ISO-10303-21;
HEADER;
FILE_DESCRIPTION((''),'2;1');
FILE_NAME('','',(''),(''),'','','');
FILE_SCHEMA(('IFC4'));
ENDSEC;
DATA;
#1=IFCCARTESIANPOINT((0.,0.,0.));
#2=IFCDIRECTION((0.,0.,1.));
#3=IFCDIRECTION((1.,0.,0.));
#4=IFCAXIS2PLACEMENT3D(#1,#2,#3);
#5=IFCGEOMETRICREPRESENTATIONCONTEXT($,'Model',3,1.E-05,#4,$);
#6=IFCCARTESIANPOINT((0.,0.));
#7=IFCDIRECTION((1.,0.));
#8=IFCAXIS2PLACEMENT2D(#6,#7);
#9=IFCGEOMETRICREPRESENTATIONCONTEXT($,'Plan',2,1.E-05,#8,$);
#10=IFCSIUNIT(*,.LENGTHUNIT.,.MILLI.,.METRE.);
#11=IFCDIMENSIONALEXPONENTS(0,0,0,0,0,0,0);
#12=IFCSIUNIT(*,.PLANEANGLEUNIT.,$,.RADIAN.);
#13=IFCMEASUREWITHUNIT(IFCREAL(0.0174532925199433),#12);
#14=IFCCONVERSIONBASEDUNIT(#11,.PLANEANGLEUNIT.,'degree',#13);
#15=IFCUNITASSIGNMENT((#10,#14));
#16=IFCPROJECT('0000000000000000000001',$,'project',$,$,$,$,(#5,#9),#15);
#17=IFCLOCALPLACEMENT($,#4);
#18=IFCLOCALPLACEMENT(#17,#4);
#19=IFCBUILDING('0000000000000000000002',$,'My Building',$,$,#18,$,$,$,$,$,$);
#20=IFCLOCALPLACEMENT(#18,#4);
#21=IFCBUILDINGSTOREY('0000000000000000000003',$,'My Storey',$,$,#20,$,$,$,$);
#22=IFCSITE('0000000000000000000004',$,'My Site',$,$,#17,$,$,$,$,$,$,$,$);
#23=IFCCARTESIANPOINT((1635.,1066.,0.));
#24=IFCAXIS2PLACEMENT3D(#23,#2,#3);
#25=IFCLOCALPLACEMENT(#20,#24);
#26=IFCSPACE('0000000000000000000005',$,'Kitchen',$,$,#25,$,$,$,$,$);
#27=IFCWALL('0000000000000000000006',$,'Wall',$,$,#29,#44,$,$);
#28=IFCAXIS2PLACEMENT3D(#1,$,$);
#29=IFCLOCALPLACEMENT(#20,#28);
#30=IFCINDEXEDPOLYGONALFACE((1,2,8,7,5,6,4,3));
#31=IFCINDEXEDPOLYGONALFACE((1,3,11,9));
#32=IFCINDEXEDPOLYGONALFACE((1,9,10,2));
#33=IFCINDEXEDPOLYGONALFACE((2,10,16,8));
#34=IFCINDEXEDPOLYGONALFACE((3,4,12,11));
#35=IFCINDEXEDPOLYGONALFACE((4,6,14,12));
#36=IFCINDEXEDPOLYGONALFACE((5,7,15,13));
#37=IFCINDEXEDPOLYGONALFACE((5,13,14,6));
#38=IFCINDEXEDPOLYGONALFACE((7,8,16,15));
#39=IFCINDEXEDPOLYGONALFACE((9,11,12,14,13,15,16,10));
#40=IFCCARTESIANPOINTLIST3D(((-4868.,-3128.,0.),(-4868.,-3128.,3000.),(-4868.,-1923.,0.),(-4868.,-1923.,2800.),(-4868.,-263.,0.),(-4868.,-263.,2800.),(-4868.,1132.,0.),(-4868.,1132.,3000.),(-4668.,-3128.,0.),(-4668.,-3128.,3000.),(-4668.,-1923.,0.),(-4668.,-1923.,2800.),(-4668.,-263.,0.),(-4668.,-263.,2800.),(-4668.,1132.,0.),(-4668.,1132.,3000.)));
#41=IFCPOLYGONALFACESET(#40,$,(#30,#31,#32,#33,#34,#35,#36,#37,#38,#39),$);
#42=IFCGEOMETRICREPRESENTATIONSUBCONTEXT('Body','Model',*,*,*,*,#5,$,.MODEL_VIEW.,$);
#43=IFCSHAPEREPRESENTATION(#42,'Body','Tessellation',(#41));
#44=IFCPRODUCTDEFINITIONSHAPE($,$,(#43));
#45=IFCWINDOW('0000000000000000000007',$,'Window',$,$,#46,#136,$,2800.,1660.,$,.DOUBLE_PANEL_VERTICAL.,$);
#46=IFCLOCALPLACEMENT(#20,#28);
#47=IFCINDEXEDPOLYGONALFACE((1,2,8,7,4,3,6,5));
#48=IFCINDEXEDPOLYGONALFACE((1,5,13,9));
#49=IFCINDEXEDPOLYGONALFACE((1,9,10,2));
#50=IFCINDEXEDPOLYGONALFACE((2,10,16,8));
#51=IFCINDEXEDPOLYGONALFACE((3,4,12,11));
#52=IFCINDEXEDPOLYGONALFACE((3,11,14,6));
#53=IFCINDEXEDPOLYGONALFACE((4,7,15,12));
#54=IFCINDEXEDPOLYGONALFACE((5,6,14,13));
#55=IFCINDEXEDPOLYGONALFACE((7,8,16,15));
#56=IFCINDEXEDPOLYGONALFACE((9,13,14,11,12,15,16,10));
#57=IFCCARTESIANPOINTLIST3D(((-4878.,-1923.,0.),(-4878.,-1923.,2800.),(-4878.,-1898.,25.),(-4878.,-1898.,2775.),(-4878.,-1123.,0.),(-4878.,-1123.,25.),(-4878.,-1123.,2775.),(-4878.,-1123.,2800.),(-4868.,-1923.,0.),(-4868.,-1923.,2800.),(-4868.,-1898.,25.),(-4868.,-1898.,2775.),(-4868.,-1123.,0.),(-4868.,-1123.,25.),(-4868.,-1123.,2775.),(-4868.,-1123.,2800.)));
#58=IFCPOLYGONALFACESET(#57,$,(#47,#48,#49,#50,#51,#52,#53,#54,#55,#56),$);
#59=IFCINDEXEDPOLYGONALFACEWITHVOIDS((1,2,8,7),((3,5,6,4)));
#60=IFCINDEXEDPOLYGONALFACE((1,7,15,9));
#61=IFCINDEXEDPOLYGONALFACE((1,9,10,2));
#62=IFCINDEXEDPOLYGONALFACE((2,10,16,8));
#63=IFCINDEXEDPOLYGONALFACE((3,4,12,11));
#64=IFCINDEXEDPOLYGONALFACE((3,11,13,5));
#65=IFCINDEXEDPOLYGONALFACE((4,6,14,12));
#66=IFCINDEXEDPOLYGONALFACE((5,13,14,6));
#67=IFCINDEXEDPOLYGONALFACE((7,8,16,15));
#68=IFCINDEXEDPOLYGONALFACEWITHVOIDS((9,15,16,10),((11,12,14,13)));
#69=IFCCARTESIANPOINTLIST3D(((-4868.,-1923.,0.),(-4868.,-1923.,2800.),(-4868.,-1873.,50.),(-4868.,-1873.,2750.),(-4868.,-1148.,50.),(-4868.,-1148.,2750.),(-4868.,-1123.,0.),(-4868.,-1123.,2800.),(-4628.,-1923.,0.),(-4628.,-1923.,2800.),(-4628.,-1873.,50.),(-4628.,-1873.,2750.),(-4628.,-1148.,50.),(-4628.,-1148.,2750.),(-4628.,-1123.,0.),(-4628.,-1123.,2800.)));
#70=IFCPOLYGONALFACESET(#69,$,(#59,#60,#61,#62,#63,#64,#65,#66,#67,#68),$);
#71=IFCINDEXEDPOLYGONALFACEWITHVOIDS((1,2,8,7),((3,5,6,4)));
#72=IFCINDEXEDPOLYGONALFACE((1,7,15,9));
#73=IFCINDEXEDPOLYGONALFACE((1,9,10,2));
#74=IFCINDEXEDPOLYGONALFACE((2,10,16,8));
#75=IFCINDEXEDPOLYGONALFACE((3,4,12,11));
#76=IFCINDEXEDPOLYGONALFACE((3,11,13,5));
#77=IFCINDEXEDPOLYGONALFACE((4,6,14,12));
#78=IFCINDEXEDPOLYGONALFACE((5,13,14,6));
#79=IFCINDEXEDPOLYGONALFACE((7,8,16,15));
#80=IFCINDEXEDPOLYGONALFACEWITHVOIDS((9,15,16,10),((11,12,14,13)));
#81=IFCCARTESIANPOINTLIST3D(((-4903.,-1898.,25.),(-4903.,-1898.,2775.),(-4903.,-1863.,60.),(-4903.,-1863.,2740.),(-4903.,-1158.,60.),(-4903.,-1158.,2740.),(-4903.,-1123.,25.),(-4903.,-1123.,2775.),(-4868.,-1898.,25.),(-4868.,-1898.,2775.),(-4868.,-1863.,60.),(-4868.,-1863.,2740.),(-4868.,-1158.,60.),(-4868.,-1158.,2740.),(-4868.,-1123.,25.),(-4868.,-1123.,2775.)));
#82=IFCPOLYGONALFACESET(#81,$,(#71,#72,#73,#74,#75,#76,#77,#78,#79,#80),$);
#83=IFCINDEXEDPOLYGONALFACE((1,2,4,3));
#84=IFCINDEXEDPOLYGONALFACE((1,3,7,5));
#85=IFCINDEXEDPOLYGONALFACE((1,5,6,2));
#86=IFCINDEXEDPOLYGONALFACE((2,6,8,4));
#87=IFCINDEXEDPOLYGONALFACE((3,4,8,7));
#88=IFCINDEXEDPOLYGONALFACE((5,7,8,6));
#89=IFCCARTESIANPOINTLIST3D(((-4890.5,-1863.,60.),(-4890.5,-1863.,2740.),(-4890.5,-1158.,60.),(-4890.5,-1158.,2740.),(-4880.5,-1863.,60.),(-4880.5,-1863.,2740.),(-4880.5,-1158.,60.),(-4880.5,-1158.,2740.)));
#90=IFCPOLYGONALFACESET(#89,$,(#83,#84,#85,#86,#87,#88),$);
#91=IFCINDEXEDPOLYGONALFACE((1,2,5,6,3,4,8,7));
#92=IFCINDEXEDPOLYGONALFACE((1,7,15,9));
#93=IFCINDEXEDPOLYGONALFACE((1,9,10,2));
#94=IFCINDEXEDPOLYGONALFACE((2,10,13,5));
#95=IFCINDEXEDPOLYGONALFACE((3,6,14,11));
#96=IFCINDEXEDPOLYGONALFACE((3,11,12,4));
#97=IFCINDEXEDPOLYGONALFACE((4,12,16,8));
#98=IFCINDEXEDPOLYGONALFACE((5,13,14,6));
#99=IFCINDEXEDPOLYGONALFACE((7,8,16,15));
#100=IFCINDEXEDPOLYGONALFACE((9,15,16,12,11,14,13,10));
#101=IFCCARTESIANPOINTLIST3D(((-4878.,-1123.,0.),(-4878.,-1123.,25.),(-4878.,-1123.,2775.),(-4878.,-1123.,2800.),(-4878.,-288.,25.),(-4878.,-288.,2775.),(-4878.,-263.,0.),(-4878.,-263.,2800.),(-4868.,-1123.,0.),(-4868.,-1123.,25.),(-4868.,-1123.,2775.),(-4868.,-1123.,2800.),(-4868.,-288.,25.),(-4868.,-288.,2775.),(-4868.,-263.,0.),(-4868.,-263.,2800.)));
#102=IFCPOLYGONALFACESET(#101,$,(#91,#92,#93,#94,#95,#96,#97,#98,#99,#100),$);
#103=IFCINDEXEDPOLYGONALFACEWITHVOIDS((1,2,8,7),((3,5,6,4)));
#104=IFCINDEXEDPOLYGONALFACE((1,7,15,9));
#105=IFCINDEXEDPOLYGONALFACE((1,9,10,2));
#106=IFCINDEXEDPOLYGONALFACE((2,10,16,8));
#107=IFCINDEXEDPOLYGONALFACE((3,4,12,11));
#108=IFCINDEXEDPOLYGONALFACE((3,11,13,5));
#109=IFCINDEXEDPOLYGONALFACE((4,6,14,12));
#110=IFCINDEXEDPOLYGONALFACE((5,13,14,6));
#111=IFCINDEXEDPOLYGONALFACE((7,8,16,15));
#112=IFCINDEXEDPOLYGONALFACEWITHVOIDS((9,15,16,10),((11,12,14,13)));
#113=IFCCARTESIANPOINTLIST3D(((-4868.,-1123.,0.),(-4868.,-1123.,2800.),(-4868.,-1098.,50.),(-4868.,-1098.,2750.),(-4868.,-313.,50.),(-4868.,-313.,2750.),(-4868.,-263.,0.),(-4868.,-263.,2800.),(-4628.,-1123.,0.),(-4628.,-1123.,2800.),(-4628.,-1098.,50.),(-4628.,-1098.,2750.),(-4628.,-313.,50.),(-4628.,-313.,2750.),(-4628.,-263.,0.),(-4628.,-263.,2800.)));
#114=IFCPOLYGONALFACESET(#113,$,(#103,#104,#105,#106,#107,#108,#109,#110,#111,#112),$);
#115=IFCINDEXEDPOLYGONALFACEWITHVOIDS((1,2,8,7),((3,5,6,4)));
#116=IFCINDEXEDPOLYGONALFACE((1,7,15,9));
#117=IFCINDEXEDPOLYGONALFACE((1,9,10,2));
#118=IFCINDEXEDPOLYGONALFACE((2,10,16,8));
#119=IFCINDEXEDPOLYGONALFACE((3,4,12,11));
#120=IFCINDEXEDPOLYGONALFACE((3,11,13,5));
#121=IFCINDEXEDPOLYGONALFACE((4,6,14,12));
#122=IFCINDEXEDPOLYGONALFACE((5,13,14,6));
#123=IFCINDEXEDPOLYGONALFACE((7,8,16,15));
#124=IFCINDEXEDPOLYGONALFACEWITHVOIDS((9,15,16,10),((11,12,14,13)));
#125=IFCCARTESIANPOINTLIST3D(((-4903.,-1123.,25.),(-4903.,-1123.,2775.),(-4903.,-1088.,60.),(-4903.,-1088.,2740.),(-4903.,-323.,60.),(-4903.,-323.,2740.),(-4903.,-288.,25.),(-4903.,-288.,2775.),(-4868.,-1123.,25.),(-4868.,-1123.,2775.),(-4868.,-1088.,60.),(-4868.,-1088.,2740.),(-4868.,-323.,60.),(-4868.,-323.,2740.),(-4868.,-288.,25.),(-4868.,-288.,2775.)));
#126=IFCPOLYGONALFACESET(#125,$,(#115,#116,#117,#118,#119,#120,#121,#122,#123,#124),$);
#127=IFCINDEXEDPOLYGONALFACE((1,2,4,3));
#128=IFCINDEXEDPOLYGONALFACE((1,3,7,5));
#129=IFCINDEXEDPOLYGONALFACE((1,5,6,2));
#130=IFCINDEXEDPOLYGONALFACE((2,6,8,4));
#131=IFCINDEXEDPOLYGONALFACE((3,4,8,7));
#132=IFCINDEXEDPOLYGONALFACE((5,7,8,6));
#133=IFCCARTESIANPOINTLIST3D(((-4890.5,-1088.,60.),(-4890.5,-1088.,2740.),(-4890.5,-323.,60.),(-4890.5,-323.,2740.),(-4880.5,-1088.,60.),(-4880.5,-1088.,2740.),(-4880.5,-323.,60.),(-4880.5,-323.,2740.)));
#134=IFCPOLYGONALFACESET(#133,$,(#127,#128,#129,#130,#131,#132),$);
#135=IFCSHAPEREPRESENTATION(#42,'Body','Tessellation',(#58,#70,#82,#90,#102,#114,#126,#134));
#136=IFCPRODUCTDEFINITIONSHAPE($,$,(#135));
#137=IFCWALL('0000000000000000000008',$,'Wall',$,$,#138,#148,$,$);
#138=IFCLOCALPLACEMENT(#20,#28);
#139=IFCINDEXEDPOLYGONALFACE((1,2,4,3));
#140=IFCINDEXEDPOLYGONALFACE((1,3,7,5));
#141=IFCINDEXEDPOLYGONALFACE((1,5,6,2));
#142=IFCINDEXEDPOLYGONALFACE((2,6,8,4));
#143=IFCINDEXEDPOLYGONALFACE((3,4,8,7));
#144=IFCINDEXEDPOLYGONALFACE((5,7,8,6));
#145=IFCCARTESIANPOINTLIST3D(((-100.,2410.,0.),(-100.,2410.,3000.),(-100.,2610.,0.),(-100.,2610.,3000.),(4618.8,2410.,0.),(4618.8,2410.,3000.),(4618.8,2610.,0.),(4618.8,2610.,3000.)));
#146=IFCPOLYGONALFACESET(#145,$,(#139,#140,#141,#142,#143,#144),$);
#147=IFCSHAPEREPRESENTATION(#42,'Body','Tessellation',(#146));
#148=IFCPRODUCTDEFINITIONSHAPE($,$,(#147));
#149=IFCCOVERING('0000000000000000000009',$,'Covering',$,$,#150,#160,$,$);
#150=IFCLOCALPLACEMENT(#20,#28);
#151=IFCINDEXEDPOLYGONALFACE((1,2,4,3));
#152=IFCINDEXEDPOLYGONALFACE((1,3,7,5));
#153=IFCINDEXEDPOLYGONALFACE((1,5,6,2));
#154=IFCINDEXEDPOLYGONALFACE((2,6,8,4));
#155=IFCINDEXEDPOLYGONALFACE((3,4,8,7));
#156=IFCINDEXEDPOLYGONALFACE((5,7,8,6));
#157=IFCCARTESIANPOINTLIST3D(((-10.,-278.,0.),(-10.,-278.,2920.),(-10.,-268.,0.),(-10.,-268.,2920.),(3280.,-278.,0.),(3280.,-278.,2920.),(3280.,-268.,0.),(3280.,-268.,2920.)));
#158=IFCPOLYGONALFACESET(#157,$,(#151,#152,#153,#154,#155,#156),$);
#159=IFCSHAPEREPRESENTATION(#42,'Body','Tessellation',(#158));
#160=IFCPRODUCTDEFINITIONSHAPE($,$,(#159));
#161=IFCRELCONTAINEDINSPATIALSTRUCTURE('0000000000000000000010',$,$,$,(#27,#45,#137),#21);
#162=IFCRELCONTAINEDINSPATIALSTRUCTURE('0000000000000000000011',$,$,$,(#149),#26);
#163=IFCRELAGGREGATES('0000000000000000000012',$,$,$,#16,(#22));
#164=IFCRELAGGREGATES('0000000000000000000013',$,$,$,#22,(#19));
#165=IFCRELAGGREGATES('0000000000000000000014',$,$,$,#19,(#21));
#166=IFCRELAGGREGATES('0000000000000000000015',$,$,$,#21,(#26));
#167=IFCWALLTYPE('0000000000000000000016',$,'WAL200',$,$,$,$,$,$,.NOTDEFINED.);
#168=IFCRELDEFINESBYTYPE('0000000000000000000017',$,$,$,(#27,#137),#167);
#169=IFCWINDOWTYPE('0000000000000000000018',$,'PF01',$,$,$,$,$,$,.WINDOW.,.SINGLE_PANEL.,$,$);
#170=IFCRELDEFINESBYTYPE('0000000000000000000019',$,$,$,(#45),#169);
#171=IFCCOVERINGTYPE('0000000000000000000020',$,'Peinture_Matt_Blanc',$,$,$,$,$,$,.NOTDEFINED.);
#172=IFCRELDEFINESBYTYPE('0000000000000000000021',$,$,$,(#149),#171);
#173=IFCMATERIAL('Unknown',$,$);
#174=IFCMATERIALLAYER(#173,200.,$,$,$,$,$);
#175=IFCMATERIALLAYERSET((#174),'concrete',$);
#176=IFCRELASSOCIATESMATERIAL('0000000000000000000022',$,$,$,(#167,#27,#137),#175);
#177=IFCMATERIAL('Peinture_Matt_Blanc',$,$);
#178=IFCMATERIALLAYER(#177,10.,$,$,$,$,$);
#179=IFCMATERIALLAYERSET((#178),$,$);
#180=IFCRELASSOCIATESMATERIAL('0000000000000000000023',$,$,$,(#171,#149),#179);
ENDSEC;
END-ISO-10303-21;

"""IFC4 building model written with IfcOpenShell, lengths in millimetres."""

from ifc_helpers import new_model, entity, si_unit, converted_unit, frame, origin_with_axes, origin_2d_with_axis, place, context, subcontext, project, spatial, line, indexed_curve, outline, extrude, clip, halfspace, shape, source, transform, mapped, material, layer, layer_set, layer_usage, type_object, type_shapes, element, fill, save


model = new_model("IFC4")

# Units and contexts
model_context = context("Model", 3, precision=1e-05, world=origin_with_axes())
plan_context = context("Plan", 2, precision=1e-05, world=origin_2d_with_axis())
body_context_1 = subcontext(model_context, "Body", "Model", "MODEL_VIEW")
body_context_2 = subcontext(plan_context, "Body", "Plan", "PLAN_VIEW")
ifc_project = project(units=[si_unit("LENGTHUNIT", "METRE", prefix="MILLI"), converted_unit("PLANEANGLEUNIT", "degree", entity("IfcReal", 0.0174532925199433), si_unit("PLANEANGLEUNIT", "RADIAN"), dimensions=[0, 0, 0, 0, 0, 0, 0])], contexts=[model_context, plan_context])

# Site, building, storey
site_placement = place(None, origin_with_axes())
site = spatial("IfcSite", under=ifc_project, at=site_placement, Name="My Site")
building_placement = place(site_placement, origin_with_axes())
building = spatial("IfcBuilding", under=site, at=building_placement, Name="My Building")
storey_placement = place(building_placement, origin_with_axes())
storey = spatial("IfcBuildingStorey", under=building, at=storey_placement, Name="My Storey")

# Shared definitions
ifc_material_1 = material(Name="Unknown")

# Shared definitions
space_1_placement = place(storey_placement, frame((1635.0, 1066.0, 0.0), z_axis=(0.0, 0.0, 1.0), x_axis=(1.0, 0.0, 0.0)))
space_1 = spatial("IfcSpace", under=storey, at=space_1_placement, Name="Kitchen")

# Shared definitions
ifc_layer_1 = layer(ifc_material_1, 200.0)
ifc_layer_set_1 = layer_set([ifc_layer_1], Name="concrete")
wall_type_1 = type_object("IfcWallType", Name="WAL200", PredefinedType="NOTDEFINED", material=ifc_layer_set_1)

# Wall, opening, window
ifc_layer_usage_1 = layer_usage(ifc_layer_set_1, "AXIS2", "POSITIVE", 0.0)
wall_1_placement = place(storey_placement, frame((-4868.0, 1132.0, 0.0), z_axis=(0.0, 0.0, 1.0), x_axis=(-0.000001, -1.0, 0.0)))
wall_1 = element("IfcWall", 1, at=wall_1_placement, inside=storey, type_object=wall_type_1, material=ifc_layer_usage_1, Name="Wall", context=body_context_1, shape_type="SweptSolid", body=[
    extrude(outline(indexed_curve([(0.0, 0.0), (0.0, 200.0), (4260.0, 200.0), (4260.0, 0.0), (0.0, 0.0)], self_intersect=False)), origin_with_axes(), (0.0, 0.0, 1.0), 3000.0),
])
shared_shape_1 = source(origin_with_axes(), body_context_1, "Body", "SweptSolid", [
    extrude(outline(indexed_curve([(0.0, 0.0), (1660.0, 0.0), (1660.0, 2800.0), (0.0, 2800.0)], segments=[line(1, 2, 3, 4, 1)])), frame((0.0, -100.0, 0.0), z_axis=(0.0, -1.0, 0.0), x_axis=(1.0, 0.0, 0.0)), (0.0, 0.0, -1.0), 400.0),
])
opening_1_placement = place(wall_1_placement, frame((3055.0, 290.0, 0.0), z_axis=(0.0, 0.0, 1.0), x_axis=(-1.0, 0.0, 0.0)))
opening_1 = element("IfcOpeningElement", 2, at=opening_1_placement, cuts=wall_1, PredefinedType="OPENING", context=body_context_1, shape_type="MappedRepresentation", body=[
    mapped(shared_shape_1, transform((0.0, 0.0, 0.0), x_axis=(1.0, 0.0, 0.0), y_axis=(0.0, 1.0, 0.0), z_axis=(0.0, 0.0, 1.0), scale=1.0)),
])
window_type = type_object("IfcWindowType", Name="PF01", PartitioningType="SINGLE_PANEL", PredefinedType="WINDOW")
shared_shape_2 = source(origin_with_axes(), body_context_1, "Body", "SweptSolid", [
    extrude(outline(indexed_curve([(800.0, 0.0), (0.0, 0.0), (0.0, 2800.0), (800.0, 2800.0), (800.0, 2775.0), (25.0, 2775.0), (25.0, 25.0), (800.0, 25.0)], segments=[line(1, 2, 3, 4, 5, 6, 7, 8, 1)])), frame((0.0, 290.0, 0.0), z_axis=(0.0, -1.0, 0.0), x_axis=(1.0, 0.0, 0.0)), (0.0, 0.0, -1.0), 10.0),
    extrude(outline(indexed_curve([(0.0, 0.0), (800.0, 0.0), (800.0, 2800.0), (0.0, 2800.0)], segments=[line(1, 2, 3, 4, 1)]), holes=[indexed_curve([(50.0, 50.0), (775.0, 50.0), (775.0, 2750.0), (50.0, 2750.0)], segments=[line(1, 2, 3, 4, 1)])]), frame((0.0, 50.0, 0.0), z_axis=(0.0, -1.0, 0.0), x_axis=(1.0, 0.0, 0.0)), (0.0, 0.0, -1.0), 240.0),
    extrude(outline(indexed_curve([(0.0, 0.0), (775.0, 0.0), (775.0, 2750.0), (0.0, 2750.0)], segments=[line(1, 2, 3, 4, 1)]), holes=[indexed_curve([(35.0, 35.0), (740.0, 35.0), (740.0, 2715.0), (35.0, 2715.0)], segments=[line(1, 2, 3, 4, 1)])]), frame((25.0, 290.0, 25.0), z_axis=(0.0, -1.0, 0.0), x_axis=(1.0, 0.0, 0.0)), (0.0, 0.0, -1.0), 35.0),
    extrude(outline(indexed_curve([(35.0, 35.0), (740.0, 35.0), (740.0, 2715.0), (35.0, 2715.0)], segments=[line(1, 2, 3, 4, 1)])), frame((25.0, 302.5, 25.0), z_axis=(0.0, -1.0, 0.0), x_axis=(1.0, 0.0, 0.0)), (0.0, 0.0, -1.0), 10.0),
    extrude(outline(indexed_curve([(0.0, 2800.0), (860.0, 2800.0), (860.0, 0.0), (0.0, 0.0), (0.0, 25.0), (835.0, 25.0), (835.0, 2775.0), (0.0, 2775.0)], segments=[line(1, 2, 3, 4, 5, 6, 7, 8, 1)])), frame((800.0, 290.0, 0.0), z_axis=(0.0, -1.0, 0.0), x_axis=(1.0, 0.0, 0.0)), (0.0, 0.0, -1.0), 10.0),
    extrude(outline(indexed_curve([(0.0, 0.0), (860.0, 0.0), (860.0, 2800.0), (0.0, 2800.0)], segments=[line(1, 2, 3, 4, 1)]), holes=[indexed_curve([(25.0, 50.0), (810.0, 50.0), (810.0, 2750.0), (25.0, 2750.0)], segments=[line(1, 2, 3, 4, 1)])]), frame((800.0, 50.0, 0.0), z_axis=(0.0, -1.0, 0.0), x_axis=(1.0, 0.0, 0.0)), (0.0, 0.0, -1.0), 240.0),
    extrude(outline(indexed_curve([(0.0, 0.0), (835.0, 0.0), (835.0, 2750.0), (0.0, 2750.0)], segments=[line(1, 2, 3, 4, 1)]), holes=[indexed_curve([(35.0, 35.0), (800.0, 35.0), (800.0, 2715.0), (35.0, 2715.0)], segments=[line(1, 2, 3, 4, 1)])]), frame((800.0, 290.0, 25.0), z_axis=(0.0, -1.0, 0.0), x_axis=(1.0, 0.0, 0.0)), (0.0, 0.0, -1.0), 35.0),
    extrude(outline(indexed_curve([(35.0, 35.0), (800.0, 35.0), (800.0, 2715.0), (35.0, 2715.0)], segments=[line(1, 2, 3, 4, 1)])), frame((800.0, 302.5, 25.0), z_axis=(0.0, -1.0, 0.0), x_axis=(1.0, 0.0, 0.0)), (0.0, 0.0, -1.0), 10.0),
])
shared_shape_3 = source(origin_with_axes(), body_context_2, "Body", "Curve2D", [
    entity("IfcIndexedPolyCurve", entity("IfcCartesianPointList2D", [[50.0, 50.0], [775.0, 50.0]])),
    entity("IfcIndexedPolyCurve", entity("IfcCartesianPointList2D", [[0.0, 300.0], [25.0, 300.0], [25.0, 290.0], [50.0, 290.0], [50.0, 50.0], [0.0, 50.0]]), [entity("IfcLineIndex", [1, 2, 3, 4, 5, 6, 1])]),
    entity("IfcIndexedPolyCurve", entity("IfcCartesianPointList2D", [[800.0, 300.0], [800.0, 300.0], [800.0, 290.0], [775.0, 290.0], [775.0, 50.0], [800.0, 50.0]])),
    entity("IfcIndexedPolyCurve", entity("IfcCartesianPointList2D", [[25.0, 290.0], [60.0, 290.0], [60.0, 325.0], [25.0, 325.0]]), [entity("IfcLineIndex", [1, 2, 3, 4, 1])]),
    entity("IfcIndexedPolyCurve", entity("IfcCartesianPointList2D", [[800.0, 290.0], [765.0, 290.0], [765.0, 325.0], [800.0, 325.0]]), [entity("IfcLineIndex", [1, 2, 3, 4, 1])]),
    entity("IfcIndexedPolyCurve", entity("IfcCartesianPointList2D", [[60.0, 290.0], [765.0, 290.0]])),
    entity("IfcIndexedPolyCurve", entity("IfcCartesianPointList2D", [[60.0, 325.0], [765.0, 325.0]])),
    entity("IfcIndexedPolyCurve", entity("IfcCartesianPointList2D", [[60.0, 307.5], [765.0, 307.5]])),
    entity("IfcIndexedPolyCurve", entity("IfcCartesianPointList2D", [[825.0, 50.0], [1610.0, 50.0]])),
    entity("IfcIndexedPolyCurve", entity("IfcCartesianPointList2D", [[800.0, 300.0], [800.0, 300.0], [800.0, 290.0], [825.0, 290.0], [825.0, 50.0], [800.0, 50.0]])),
    entity("IfcIndexedPolyCurve", entity("IfcCartesianPointList2D", [[1660.0, 300.0], [1635.0, 300.0], [1635.0, 290.0], [1610.0, 290.0], [1610.0, 50.0], [1660.0, 50.0]]), [entity("IfcLineIndex", [1, 2, 3, 4, 5, 6, 1])]),
    entity("IfcIndexedPolyCurve", entity("IfcCartesianPointList2D", [[800.0, 290.0], [835.0, 290.0], [835.0, 325.0], [800.0, 325.0]]), [entity("IfcLineIndex", [1, 2, 3, 4, 1])]),
    entity("IfcIndexedPolyCurve", entity("IfcCartesianPointList2D", [[1635.0, 290.0], [1600.0, 290.0], [1600.0, 325.0], [1635.0, 325.0]]), [entity("IfcLineIndex", [1, 2, 3, 4, 1])]),
    entity("IfcIndexedPolyCurve", entity("IfcCartesianPointList2D", [[835.0, 290.0], [1600.0, 290.0]])),
    entity("IfcIndexedPolyCurve", entity("IfcCartesianPointList2D", [[835.0, 325.0], [1600.0, 325.0]])),
    entity("IfcIndexedPolyCurve", entity("IfcCartesianPointList2D", [[835.0, 307.5], [1600.0, 307.5]])),
])
type_shapes(window_type, [shared_shape_2, shared_shape_3])
window_placement = place(opening_1_placement, frame((0.0, 0.0, 0.0), z_axis=(0.0, 0.0, 1.0), x_axis=(1.0, 0.0, 0.0)))
window = element("IfcWindow", 3, at=window_placement, inside=storey, type_object=window_type, Name="Window", OverallHeight=2800.0, OverallWidth=1660.0, PartitioningType="DOUBLE_PANEL_VERTICAL", shapes=[
    shape(body_context_1, "Body", "MappedRepresentation", [mapped(shared_shape_2, transform((0.0, 0.0, 0.0), x_axis=(1.0, 0.0, 0.0), y_axis=(0.0, 1.0, 0.0), z_axis=(0.0, 0.0, 1.0), scale=1.0))]),
    shape(body_context_2, "Body", "MappedRepresentation", [mapped(shared_shape_3, transform((0.0, 0.0, 0.0), x_axis=(1.0, 0.0, 0.0), y_axis=(0.0, 1.0, 0.0), z_axis=(0.0, 0.0, 1.0), scale=1.0))]),
])
fill(opening_1, window)

# Wall
ifc_layer_usage_2 = layer_usage(ifc_layer_set_1, "AXIS2", "POSITIVE", 0.0)
wall_2_placement = place(storey_placement, frame((-100.0, 2410.0, 0.0), z_axis=(0.0, 0.0, 1.0), x_axis=(1.0, -0.000001, 0.0)))
element("IfcWall", 4, at=wall_2_placement, inside=storey, type_object=wall_type_1, material=ifc_layer_usage_2, Name="Wall", context=body_context_1, shape_type="SweptSolid", body=[
    extrude(outline(indexed_curve([(0.0, 0.0), (0.0, 200.0), (4718.8, 200.0), (4718.8, 0.0), (0.0, 0.0)], self_intersect=False)), origin_with_axes(), (0.0, 0.0, 1.0), 3000.0),
])

# Shared definitions
ifc_material_2 = material(Name="Peinture_Matt_Blanc")
ifc_layer_2 = layer(ifc_material_2, 10.0)
ifc_layer_set_2 = layer_set([ifc_layer_2])
covering_type_1 = type_object("IfcCoveringType", Name="Peinture_Matt_Blanc", PredefinedType="NOTDEFINED", material=ifc_layer_set_2)

# Covering
ifc_layer_usage_3 = layer_usage(ifc_layer_set_2, "AXIS2", "POSITIVE", 0.0)
covering_1_placement = place(space_1_placement, frame((-1645.0, -1344.0, 0.0), z_axis=(0.0, 0.0, 1.0), x_axis=(1.0, -0.000001, 0.0)))
element("IfcCovering", 5, at=covering_1_placement, inside=space_1, type_object=covering_type_1, material=ifc_layer_usage_3, Name="Covering", context=body_context_1, shape_type="Clipping", body=[
    clip(clip(extrude(outline(indexed_curve([(0.0, 0.0), (0.0, 10.0), (3290.0, 10.0), (3290.0, 0.0), (0.0, 0.0)], self_intersect=False)), origin_with_axes(), (0.0, 0.0, 1.0), 2920.0), halfspace(frame((0.0, 0.0, 2920.0), z_axis=(0.0, 0.0, 1.0), x_axis=(-1.0, 0.0, 0.0)), False)), halfspace(frame((0.0, 0.0, 2920.0), z_axis=(0.0, 0.0, 1.0), x_axis=(-1.0, 0.0, 0.0)), False)),
])

save(model, "model.ifc")
